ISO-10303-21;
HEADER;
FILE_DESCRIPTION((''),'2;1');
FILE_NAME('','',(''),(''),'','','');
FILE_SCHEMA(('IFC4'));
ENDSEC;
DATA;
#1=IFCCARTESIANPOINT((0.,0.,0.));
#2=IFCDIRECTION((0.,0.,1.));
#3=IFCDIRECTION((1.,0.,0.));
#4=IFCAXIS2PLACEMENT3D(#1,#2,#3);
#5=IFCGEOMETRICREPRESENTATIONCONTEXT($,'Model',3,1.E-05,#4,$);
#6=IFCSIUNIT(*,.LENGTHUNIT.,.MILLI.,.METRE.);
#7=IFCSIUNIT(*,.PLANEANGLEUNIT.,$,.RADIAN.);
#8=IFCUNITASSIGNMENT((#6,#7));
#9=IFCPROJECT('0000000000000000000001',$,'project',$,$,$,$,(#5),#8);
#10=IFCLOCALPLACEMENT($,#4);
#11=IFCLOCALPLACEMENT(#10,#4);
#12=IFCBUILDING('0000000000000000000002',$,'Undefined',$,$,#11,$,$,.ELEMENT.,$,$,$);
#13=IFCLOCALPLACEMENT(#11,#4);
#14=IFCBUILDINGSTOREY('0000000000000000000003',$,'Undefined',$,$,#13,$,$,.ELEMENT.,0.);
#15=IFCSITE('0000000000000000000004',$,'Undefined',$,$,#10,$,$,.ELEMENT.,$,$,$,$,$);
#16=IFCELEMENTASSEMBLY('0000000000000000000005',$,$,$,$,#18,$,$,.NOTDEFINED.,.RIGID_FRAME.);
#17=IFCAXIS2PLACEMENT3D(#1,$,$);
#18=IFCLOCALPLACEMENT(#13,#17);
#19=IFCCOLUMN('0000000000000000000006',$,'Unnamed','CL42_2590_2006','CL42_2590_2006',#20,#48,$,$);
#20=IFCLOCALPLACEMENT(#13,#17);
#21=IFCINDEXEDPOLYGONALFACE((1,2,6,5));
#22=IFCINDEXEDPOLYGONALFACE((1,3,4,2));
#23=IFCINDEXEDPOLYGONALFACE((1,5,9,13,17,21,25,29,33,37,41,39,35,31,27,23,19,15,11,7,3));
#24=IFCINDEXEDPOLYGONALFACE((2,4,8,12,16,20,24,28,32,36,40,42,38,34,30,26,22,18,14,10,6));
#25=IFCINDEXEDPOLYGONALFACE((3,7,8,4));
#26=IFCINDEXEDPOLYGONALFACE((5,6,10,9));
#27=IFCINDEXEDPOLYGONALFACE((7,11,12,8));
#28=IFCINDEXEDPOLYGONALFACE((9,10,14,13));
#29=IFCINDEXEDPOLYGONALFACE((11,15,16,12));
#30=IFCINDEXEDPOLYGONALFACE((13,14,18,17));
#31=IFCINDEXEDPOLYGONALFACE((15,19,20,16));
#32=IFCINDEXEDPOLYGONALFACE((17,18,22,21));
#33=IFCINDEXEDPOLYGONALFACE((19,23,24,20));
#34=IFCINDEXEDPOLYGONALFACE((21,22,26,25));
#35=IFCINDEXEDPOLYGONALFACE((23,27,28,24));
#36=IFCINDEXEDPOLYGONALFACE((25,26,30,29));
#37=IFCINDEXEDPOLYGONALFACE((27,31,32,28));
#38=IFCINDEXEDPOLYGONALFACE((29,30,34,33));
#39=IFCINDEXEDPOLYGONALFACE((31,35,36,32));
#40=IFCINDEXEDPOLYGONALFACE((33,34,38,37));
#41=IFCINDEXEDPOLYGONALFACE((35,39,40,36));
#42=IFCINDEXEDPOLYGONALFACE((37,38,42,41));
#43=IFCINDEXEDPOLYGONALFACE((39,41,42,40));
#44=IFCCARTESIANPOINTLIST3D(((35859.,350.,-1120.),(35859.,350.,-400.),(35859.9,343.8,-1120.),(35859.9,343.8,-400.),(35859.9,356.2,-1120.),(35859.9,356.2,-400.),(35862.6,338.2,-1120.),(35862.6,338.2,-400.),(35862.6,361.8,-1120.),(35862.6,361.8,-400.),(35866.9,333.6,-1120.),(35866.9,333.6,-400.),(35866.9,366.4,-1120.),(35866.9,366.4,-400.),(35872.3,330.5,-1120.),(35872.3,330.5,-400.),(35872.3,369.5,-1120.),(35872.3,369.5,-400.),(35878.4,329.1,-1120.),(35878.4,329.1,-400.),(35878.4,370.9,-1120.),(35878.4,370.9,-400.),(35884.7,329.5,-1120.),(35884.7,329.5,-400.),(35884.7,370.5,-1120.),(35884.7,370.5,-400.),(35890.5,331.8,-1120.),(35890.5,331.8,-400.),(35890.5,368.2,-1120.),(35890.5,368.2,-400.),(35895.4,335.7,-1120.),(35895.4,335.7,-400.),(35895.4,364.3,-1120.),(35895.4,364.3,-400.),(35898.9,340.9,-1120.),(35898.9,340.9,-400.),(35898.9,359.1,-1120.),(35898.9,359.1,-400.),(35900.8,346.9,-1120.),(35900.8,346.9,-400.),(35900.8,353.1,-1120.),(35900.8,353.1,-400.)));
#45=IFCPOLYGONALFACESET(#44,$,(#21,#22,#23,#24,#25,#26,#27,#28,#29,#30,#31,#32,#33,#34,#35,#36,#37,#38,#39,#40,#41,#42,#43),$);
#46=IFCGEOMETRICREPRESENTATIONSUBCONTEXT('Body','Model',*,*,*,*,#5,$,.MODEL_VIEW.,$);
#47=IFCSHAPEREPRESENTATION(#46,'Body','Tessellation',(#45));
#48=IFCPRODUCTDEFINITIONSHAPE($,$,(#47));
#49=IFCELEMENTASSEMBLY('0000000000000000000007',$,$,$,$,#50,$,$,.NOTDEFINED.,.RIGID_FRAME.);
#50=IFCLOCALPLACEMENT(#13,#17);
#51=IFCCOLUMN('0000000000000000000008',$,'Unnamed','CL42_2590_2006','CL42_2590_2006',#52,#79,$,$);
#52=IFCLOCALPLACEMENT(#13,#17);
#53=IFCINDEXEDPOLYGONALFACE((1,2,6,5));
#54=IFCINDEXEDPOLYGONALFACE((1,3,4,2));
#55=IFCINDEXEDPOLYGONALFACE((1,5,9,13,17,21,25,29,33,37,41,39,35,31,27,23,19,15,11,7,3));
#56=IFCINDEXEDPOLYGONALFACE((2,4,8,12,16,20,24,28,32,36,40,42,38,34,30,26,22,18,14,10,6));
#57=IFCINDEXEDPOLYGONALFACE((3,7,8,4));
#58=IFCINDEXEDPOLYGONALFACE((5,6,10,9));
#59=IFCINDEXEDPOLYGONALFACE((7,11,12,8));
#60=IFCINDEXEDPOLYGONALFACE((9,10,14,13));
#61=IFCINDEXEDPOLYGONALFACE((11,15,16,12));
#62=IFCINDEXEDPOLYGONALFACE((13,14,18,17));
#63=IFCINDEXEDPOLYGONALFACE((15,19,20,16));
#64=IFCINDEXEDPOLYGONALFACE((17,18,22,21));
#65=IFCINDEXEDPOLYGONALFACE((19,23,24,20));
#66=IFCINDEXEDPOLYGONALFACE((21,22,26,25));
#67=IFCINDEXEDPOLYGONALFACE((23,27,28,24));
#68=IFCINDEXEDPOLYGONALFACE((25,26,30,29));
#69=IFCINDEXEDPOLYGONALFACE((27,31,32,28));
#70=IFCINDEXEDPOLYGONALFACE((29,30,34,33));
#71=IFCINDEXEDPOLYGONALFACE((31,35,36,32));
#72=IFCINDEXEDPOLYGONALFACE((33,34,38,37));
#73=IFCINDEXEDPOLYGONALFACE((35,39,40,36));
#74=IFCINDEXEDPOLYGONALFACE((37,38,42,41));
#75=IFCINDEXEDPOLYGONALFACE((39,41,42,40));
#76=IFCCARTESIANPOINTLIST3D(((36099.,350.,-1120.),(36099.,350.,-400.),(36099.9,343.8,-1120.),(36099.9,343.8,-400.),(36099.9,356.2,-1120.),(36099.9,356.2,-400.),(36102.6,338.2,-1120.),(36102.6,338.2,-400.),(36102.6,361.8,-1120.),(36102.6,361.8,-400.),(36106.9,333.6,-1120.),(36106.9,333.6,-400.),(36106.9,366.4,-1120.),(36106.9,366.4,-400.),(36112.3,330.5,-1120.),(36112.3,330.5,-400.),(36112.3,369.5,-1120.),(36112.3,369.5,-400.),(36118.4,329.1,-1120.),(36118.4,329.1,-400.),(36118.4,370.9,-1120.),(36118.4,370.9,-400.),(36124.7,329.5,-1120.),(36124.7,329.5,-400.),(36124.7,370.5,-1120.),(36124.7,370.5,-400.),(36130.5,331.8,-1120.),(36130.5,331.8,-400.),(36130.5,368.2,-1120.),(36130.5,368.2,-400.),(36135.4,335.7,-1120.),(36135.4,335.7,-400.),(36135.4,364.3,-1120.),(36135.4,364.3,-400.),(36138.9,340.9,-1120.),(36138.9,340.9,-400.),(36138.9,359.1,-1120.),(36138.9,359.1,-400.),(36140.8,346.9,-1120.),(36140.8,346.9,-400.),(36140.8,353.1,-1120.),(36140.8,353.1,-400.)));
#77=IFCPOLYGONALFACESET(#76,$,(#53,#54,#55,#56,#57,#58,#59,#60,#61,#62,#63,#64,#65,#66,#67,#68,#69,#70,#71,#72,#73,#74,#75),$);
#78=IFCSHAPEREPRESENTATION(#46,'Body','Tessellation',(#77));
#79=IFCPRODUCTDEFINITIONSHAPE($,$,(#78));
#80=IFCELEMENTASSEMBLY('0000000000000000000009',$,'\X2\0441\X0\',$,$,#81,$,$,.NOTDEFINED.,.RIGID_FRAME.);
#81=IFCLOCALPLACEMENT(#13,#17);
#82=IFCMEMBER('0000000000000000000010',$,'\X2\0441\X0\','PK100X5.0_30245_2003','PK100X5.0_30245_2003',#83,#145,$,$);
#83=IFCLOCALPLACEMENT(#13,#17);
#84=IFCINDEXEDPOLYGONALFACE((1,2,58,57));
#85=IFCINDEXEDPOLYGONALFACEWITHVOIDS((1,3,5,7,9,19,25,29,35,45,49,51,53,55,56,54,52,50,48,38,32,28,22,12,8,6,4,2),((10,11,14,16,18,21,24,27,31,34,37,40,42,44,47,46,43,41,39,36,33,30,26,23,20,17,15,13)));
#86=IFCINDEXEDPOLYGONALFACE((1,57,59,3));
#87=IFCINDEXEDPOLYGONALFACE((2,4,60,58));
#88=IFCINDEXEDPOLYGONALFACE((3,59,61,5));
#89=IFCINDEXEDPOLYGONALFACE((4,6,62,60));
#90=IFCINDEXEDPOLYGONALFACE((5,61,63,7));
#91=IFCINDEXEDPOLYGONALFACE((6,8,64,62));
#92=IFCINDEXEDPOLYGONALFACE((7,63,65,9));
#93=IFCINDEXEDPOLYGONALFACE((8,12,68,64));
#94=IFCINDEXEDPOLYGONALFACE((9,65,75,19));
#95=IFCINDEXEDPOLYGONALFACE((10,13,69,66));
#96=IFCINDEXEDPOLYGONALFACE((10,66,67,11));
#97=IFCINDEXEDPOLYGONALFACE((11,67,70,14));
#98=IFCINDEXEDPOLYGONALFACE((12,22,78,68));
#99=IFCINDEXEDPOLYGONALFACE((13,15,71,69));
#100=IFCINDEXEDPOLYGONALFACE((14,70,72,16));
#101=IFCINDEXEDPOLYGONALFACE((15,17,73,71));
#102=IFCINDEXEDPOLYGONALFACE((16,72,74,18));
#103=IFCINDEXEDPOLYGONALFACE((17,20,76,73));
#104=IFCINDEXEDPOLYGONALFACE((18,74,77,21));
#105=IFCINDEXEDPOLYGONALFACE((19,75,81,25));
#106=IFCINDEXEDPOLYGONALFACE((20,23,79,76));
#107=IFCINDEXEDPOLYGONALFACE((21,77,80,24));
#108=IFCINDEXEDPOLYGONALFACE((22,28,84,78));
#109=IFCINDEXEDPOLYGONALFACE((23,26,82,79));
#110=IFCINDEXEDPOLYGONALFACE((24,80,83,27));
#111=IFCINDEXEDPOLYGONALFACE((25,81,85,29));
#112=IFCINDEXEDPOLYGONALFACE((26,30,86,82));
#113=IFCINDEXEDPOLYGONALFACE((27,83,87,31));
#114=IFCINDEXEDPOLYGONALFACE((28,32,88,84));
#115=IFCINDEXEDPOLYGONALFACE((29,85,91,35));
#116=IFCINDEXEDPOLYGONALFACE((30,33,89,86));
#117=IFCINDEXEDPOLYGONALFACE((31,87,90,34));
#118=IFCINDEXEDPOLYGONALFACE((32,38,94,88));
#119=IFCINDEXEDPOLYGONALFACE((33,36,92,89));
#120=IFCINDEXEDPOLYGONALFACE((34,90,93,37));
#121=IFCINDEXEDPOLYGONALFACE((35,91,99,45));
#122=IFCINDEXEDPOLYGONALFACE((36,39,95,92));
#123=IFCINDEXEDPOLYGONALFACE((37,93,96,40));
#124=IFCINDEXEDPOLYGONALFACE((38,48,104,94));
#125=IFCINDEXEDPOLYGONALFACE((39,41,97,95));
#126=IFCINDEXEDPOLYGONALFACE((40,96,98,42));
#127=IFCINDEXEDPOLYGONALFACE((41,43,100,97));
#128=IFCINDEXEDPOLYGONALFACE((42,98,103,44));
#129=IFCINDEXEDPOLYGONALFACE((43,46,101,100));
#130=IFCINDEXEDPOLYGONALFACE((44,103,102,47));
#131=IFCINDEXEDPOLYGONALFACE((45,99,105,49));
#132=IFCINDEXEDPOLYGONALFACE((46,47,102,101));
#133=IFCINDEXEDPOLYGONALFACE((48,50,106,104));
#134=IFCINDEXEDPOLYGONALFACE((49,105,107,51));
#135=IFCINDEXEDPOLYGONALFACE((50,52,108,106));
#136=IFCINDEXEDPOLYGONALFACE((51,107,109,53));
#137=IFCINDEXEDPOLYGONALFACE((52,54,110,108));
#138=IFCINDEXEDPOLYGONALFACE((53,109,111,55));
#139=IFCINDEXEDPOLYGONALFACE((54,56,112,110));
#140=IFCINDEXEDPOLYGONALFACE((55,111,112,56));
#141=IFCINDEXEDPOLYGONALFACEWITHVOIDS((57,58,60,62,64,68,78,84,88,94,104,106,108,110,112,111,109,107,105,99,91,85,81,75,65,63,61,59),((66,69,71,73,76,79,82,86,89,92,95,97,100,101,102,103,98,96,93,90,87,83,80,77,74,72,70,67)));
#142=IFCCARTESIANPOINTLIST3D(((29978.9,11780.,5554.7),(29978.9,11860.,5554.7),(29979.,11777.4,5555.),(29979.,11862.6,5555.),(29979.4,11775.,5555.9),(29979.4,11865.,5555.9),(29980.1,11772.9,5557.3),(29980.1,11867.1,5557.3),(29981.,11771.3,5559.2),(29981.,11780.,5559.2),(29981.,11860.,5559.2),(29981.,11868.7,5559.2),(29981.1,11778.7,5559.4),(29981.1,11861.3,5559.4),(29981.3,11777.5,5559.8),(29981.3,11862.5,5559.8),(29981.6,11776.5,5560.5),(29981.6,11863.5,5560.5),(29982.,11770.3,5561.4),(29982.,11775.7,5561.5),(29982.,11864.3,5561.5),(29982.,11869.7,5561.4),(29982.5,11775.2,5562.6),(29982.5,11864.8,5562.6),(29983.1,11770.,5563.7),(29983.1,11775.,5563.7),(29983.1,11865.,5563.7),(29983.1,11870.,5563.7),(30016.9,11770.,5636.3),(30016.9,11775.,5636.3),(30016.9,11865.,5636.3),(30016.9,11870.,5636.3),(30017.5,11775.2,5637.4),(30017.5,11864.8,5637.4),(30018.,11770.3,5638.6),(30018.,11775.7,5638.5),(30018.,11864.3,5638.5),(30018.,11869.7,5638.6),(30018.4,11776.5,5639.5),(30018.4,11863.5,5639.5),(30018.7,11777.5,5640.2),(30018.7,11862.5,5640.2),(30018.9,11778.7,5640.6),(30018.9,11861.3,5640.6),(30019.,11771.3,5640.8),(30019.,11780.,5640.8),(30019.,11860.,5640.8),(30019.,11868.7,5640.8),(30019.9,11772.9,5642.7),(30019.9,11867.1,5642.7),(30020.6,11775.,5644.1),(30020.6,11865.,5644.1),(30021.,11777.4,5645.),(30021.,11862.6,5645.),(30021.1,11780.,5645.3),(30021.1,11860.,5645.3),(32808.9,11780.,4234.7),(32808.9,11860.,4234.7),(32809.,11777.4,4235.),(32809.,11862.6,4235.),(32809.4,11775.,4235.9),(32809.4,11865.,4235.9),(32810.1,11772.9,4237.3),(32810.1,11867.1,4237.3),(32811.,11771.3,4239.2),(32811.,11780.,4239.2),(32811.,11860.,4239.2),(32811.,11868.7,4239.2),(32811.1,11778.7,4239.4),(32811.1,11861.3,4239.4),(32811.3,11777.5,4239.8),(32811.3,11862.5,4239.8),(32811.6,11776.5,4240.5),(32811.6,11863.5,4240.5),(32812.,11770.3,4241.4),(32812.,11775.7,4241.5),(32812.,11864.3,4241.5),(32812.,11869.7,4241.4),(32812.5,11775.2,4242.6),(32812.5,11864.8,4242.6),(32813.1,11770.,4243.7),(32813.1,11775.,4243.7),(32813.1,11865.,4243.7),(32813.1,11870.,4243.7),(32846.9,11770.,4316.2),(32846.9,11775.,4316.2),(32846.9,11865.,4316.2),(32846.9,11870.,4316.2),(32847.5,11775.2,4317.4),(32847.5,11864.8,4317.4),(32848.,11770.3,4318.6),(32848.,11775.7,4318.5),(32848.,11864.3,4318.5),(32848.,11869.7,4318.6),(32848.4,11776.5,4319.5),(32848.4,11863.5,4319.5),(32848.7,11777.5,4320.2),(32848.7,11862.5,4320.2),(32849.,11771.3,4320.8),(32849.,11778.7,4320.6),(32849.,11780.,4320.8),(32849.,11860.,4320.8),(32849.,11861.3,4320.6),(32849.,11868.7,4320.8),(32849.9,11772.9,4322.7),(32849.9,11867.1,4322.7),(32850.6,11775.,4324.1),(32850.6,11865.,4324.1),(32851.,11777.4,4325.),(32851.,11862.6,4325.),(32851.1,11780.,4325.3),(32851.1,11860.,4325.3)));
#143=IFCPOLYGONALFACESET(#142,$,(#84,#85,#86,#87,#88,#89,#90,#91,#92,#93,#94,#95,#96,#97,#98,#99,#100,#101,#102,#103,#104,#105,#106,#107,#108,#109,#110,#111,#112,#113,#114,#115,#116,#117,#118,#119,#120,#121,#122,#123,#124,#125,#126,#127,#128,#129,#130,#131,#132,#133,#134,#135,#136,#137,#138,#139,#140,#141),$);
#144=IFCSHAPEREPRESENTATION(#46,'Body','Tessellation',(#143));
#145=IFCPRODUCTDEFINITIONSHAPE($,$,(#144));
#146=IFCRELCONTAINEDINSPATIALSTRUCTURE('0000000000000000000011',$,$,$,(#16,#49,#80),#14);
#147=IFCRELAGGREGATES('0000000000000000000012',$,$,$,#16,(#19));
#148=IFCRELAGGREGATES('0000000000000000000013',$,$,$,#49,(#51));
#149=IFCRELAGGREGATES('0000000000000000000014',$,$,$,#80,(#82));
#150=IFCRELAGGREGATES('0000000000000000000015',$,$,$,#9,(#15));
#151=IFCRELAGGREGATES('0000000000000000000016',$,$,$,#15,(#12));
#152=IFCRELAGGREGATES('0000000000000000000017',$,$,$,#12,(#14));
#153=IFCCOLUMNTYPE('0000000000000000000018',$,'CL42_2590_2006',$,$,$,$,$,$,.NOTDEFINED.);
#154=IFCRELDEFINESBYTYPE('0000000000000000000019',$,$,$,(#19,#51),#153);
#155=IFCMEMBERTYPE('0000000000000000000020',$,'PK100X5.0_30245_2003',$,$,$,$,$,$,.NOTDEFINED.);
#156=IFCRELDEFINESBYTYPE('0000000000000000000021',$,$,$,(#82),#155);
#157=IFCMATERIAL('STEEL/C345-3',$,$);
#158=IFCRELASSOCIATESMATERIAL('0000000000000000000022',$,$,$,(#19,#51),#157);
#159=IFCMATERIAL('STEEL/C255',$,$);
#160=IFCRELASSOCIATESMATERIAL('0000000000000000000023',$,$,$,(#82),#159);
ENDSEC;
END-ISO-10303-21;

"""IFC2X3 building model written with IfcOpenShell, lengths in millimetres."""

from ifc_helpers import new_model, si_unit, frame, origin_with_axes, origin_2d_with_axis, place, context, subcontext, project, spatial, hollow_rectangle, circle, extrude, material, type_object, element, aggregate, save


model = new_model("IFC2X3")

# Units and contexts
model_context = context("Model", 3, precision=1e-05, world=origin_with_axes())
body_context = subcontext(model_context, "Body", "Model", "MODEL_VIEW")
ifc_project = project(units=[si_unit("LENGTHUNIT", "METRE", prefix="MILLI"), si_unit("PLANEANGLEUNIT", "RADIAN")], contexts=[model_context])

# Site, building, storey
site_placement = place(None, origin_with_axes())
site = spatial("IfcSite", under=ifc_project, at=site_placement, Name="Undefined", CompositionType="ELEMENT")
building_placement = place(site_placement, origin_with_axes())
building = spatial("IfcBuilding", under=site, at=building_placement, Name="Undefined", CompositionType="ELEMENT")
storey_placement = place(building_placement, origin_with_axes())
storey = spatial("IfcBuildingStorey", under=building, at=storey_placement, Name="Undefined", CompositionType="ELEMENT", Elevation=0.0)

# Element assemblies, columns
ifc_material_1 = material(Name="STEEL/C255")
ifc_material_2 = material(Name="STEEL/C345-3")
column_type_1 = type_object("IfcColumnType", Name="CL42_2590_2006", PredefinedType="NOTDEFINED")
assembly_1_placement = place(storey_placement, origin_with_axes())
assembly_1 = element("IfcElementAssembly", 1, at=assembly_1_placement, inside=storey, AssemblyPlace="NOTDEFINED", PredefinedType="RIGID_FRAME")
column_1_placement = place(assembly_1_placement, frame((35880.0, 350.0, -1120.0), z_axis=(0.0, 0.0, 1.0), x_axis=(0.0, 1.0, 0.0)))
column_1 = element("IfcColumn", 2, at=column_1_placement, type_object=column_type_1, material=ifc_material_2, Name="Unnamed", Description="CL42_2590_2006", ObjectType="CL42_2590_2006", context=body_context, shape_type="SweptSolid", body=[
    extrude(circle(Radius=21.0, at=origin_2d_with_axis()), frame((0.0, 0.0, 720.0), z_axis=(0.0, 0.0, -1.0), x_axis=(0.0, 1.0, 0.0)), (0.0, 0.0, 1.0), 720.0),
])
aggregate(assembly_1, [column_1])
assembly_2_placement = place(storey_placement, origin_with_axes())
assembly_2 = element("IfcElementAssembly", 3, at=assembly_2_placement, inside=storey, AssemblyPlace="NOTDEFINED", PredefinedType="RIGID_FRAME")
column_2_placement = place(assembly_2_placement, frame((36120.0, 350.0, -1120.0), z_axis=(0.0, 0.0, 1.0), x_axis=(0.0, 1.0, 0.0)))
column_2 = element("IfcColumn", 4, at=column_2_placement, type_object=column_type_1, material=ifc_material_2, Name="Unnamed", Description="CL42_2590_2006", ObjectType="CL42_2590_2006", context=body_context, shape_type="SweptSolid", body=[
    extrude(circle(Radius=21.0, at=origin_2d_with_axis()), frame((0.0, 0.0, 720.0), z_axis=(0.0, 0.0, -1.0), x_axis=(0.0, 1.0, 0.0)), (0.0, 0.0, 1.0), 720.0),
])
aggregate(assembly_2, [column_2])

# Element assembly, member
assembly_3_placement = place(storey_placement, origin_with_axes())
assembly_3 = element("IfcElementAssembly", 5, at=assembly_3_placement, inside=storey, Name="с", AssemblyPlace="NOTDEFINED", PredefinedType="RIGID_FRAME")
member_type = type_object("IfcMemberType", Name="PK100X5.0_30245_2003", PredefinedType="NOTDEFINED")
member_1_placement = place(assembly_3_placement, frame((32830.0, 11820.0, 4280.0), z_axis=(0.0, -1.0, 0.0), x_axis=(-0.906265, 0.0, 0.42271)))
member_1 = element("IfcMember", 6, at=member_1_placement, type_object=member_type, material=ifc_material_1, Name="с", Description="PK100X5.0_30245_2003", ObjectType="PK100X5.0_30245_2003", context=body_context, shape_type="SweptSolid", body=[
    extrude(hollow_rectangle(XDim=100.0, YDim=100.0, WallThickness=5.0, InnerFilletRadius=5.0, OuterFilletRadius=10.0, at=origin_2d_with_axis()), frame((3122.7, 0.0, 0.0), z_axis=(-1.0, 0.0, 0.0), x_axis=(0.0, -1.0, 0.0)), (0.0, 0.0, 1.0), 3122.7),
])
aggregate(assembly_3, [member_1])

save(model, "model.ifc")
